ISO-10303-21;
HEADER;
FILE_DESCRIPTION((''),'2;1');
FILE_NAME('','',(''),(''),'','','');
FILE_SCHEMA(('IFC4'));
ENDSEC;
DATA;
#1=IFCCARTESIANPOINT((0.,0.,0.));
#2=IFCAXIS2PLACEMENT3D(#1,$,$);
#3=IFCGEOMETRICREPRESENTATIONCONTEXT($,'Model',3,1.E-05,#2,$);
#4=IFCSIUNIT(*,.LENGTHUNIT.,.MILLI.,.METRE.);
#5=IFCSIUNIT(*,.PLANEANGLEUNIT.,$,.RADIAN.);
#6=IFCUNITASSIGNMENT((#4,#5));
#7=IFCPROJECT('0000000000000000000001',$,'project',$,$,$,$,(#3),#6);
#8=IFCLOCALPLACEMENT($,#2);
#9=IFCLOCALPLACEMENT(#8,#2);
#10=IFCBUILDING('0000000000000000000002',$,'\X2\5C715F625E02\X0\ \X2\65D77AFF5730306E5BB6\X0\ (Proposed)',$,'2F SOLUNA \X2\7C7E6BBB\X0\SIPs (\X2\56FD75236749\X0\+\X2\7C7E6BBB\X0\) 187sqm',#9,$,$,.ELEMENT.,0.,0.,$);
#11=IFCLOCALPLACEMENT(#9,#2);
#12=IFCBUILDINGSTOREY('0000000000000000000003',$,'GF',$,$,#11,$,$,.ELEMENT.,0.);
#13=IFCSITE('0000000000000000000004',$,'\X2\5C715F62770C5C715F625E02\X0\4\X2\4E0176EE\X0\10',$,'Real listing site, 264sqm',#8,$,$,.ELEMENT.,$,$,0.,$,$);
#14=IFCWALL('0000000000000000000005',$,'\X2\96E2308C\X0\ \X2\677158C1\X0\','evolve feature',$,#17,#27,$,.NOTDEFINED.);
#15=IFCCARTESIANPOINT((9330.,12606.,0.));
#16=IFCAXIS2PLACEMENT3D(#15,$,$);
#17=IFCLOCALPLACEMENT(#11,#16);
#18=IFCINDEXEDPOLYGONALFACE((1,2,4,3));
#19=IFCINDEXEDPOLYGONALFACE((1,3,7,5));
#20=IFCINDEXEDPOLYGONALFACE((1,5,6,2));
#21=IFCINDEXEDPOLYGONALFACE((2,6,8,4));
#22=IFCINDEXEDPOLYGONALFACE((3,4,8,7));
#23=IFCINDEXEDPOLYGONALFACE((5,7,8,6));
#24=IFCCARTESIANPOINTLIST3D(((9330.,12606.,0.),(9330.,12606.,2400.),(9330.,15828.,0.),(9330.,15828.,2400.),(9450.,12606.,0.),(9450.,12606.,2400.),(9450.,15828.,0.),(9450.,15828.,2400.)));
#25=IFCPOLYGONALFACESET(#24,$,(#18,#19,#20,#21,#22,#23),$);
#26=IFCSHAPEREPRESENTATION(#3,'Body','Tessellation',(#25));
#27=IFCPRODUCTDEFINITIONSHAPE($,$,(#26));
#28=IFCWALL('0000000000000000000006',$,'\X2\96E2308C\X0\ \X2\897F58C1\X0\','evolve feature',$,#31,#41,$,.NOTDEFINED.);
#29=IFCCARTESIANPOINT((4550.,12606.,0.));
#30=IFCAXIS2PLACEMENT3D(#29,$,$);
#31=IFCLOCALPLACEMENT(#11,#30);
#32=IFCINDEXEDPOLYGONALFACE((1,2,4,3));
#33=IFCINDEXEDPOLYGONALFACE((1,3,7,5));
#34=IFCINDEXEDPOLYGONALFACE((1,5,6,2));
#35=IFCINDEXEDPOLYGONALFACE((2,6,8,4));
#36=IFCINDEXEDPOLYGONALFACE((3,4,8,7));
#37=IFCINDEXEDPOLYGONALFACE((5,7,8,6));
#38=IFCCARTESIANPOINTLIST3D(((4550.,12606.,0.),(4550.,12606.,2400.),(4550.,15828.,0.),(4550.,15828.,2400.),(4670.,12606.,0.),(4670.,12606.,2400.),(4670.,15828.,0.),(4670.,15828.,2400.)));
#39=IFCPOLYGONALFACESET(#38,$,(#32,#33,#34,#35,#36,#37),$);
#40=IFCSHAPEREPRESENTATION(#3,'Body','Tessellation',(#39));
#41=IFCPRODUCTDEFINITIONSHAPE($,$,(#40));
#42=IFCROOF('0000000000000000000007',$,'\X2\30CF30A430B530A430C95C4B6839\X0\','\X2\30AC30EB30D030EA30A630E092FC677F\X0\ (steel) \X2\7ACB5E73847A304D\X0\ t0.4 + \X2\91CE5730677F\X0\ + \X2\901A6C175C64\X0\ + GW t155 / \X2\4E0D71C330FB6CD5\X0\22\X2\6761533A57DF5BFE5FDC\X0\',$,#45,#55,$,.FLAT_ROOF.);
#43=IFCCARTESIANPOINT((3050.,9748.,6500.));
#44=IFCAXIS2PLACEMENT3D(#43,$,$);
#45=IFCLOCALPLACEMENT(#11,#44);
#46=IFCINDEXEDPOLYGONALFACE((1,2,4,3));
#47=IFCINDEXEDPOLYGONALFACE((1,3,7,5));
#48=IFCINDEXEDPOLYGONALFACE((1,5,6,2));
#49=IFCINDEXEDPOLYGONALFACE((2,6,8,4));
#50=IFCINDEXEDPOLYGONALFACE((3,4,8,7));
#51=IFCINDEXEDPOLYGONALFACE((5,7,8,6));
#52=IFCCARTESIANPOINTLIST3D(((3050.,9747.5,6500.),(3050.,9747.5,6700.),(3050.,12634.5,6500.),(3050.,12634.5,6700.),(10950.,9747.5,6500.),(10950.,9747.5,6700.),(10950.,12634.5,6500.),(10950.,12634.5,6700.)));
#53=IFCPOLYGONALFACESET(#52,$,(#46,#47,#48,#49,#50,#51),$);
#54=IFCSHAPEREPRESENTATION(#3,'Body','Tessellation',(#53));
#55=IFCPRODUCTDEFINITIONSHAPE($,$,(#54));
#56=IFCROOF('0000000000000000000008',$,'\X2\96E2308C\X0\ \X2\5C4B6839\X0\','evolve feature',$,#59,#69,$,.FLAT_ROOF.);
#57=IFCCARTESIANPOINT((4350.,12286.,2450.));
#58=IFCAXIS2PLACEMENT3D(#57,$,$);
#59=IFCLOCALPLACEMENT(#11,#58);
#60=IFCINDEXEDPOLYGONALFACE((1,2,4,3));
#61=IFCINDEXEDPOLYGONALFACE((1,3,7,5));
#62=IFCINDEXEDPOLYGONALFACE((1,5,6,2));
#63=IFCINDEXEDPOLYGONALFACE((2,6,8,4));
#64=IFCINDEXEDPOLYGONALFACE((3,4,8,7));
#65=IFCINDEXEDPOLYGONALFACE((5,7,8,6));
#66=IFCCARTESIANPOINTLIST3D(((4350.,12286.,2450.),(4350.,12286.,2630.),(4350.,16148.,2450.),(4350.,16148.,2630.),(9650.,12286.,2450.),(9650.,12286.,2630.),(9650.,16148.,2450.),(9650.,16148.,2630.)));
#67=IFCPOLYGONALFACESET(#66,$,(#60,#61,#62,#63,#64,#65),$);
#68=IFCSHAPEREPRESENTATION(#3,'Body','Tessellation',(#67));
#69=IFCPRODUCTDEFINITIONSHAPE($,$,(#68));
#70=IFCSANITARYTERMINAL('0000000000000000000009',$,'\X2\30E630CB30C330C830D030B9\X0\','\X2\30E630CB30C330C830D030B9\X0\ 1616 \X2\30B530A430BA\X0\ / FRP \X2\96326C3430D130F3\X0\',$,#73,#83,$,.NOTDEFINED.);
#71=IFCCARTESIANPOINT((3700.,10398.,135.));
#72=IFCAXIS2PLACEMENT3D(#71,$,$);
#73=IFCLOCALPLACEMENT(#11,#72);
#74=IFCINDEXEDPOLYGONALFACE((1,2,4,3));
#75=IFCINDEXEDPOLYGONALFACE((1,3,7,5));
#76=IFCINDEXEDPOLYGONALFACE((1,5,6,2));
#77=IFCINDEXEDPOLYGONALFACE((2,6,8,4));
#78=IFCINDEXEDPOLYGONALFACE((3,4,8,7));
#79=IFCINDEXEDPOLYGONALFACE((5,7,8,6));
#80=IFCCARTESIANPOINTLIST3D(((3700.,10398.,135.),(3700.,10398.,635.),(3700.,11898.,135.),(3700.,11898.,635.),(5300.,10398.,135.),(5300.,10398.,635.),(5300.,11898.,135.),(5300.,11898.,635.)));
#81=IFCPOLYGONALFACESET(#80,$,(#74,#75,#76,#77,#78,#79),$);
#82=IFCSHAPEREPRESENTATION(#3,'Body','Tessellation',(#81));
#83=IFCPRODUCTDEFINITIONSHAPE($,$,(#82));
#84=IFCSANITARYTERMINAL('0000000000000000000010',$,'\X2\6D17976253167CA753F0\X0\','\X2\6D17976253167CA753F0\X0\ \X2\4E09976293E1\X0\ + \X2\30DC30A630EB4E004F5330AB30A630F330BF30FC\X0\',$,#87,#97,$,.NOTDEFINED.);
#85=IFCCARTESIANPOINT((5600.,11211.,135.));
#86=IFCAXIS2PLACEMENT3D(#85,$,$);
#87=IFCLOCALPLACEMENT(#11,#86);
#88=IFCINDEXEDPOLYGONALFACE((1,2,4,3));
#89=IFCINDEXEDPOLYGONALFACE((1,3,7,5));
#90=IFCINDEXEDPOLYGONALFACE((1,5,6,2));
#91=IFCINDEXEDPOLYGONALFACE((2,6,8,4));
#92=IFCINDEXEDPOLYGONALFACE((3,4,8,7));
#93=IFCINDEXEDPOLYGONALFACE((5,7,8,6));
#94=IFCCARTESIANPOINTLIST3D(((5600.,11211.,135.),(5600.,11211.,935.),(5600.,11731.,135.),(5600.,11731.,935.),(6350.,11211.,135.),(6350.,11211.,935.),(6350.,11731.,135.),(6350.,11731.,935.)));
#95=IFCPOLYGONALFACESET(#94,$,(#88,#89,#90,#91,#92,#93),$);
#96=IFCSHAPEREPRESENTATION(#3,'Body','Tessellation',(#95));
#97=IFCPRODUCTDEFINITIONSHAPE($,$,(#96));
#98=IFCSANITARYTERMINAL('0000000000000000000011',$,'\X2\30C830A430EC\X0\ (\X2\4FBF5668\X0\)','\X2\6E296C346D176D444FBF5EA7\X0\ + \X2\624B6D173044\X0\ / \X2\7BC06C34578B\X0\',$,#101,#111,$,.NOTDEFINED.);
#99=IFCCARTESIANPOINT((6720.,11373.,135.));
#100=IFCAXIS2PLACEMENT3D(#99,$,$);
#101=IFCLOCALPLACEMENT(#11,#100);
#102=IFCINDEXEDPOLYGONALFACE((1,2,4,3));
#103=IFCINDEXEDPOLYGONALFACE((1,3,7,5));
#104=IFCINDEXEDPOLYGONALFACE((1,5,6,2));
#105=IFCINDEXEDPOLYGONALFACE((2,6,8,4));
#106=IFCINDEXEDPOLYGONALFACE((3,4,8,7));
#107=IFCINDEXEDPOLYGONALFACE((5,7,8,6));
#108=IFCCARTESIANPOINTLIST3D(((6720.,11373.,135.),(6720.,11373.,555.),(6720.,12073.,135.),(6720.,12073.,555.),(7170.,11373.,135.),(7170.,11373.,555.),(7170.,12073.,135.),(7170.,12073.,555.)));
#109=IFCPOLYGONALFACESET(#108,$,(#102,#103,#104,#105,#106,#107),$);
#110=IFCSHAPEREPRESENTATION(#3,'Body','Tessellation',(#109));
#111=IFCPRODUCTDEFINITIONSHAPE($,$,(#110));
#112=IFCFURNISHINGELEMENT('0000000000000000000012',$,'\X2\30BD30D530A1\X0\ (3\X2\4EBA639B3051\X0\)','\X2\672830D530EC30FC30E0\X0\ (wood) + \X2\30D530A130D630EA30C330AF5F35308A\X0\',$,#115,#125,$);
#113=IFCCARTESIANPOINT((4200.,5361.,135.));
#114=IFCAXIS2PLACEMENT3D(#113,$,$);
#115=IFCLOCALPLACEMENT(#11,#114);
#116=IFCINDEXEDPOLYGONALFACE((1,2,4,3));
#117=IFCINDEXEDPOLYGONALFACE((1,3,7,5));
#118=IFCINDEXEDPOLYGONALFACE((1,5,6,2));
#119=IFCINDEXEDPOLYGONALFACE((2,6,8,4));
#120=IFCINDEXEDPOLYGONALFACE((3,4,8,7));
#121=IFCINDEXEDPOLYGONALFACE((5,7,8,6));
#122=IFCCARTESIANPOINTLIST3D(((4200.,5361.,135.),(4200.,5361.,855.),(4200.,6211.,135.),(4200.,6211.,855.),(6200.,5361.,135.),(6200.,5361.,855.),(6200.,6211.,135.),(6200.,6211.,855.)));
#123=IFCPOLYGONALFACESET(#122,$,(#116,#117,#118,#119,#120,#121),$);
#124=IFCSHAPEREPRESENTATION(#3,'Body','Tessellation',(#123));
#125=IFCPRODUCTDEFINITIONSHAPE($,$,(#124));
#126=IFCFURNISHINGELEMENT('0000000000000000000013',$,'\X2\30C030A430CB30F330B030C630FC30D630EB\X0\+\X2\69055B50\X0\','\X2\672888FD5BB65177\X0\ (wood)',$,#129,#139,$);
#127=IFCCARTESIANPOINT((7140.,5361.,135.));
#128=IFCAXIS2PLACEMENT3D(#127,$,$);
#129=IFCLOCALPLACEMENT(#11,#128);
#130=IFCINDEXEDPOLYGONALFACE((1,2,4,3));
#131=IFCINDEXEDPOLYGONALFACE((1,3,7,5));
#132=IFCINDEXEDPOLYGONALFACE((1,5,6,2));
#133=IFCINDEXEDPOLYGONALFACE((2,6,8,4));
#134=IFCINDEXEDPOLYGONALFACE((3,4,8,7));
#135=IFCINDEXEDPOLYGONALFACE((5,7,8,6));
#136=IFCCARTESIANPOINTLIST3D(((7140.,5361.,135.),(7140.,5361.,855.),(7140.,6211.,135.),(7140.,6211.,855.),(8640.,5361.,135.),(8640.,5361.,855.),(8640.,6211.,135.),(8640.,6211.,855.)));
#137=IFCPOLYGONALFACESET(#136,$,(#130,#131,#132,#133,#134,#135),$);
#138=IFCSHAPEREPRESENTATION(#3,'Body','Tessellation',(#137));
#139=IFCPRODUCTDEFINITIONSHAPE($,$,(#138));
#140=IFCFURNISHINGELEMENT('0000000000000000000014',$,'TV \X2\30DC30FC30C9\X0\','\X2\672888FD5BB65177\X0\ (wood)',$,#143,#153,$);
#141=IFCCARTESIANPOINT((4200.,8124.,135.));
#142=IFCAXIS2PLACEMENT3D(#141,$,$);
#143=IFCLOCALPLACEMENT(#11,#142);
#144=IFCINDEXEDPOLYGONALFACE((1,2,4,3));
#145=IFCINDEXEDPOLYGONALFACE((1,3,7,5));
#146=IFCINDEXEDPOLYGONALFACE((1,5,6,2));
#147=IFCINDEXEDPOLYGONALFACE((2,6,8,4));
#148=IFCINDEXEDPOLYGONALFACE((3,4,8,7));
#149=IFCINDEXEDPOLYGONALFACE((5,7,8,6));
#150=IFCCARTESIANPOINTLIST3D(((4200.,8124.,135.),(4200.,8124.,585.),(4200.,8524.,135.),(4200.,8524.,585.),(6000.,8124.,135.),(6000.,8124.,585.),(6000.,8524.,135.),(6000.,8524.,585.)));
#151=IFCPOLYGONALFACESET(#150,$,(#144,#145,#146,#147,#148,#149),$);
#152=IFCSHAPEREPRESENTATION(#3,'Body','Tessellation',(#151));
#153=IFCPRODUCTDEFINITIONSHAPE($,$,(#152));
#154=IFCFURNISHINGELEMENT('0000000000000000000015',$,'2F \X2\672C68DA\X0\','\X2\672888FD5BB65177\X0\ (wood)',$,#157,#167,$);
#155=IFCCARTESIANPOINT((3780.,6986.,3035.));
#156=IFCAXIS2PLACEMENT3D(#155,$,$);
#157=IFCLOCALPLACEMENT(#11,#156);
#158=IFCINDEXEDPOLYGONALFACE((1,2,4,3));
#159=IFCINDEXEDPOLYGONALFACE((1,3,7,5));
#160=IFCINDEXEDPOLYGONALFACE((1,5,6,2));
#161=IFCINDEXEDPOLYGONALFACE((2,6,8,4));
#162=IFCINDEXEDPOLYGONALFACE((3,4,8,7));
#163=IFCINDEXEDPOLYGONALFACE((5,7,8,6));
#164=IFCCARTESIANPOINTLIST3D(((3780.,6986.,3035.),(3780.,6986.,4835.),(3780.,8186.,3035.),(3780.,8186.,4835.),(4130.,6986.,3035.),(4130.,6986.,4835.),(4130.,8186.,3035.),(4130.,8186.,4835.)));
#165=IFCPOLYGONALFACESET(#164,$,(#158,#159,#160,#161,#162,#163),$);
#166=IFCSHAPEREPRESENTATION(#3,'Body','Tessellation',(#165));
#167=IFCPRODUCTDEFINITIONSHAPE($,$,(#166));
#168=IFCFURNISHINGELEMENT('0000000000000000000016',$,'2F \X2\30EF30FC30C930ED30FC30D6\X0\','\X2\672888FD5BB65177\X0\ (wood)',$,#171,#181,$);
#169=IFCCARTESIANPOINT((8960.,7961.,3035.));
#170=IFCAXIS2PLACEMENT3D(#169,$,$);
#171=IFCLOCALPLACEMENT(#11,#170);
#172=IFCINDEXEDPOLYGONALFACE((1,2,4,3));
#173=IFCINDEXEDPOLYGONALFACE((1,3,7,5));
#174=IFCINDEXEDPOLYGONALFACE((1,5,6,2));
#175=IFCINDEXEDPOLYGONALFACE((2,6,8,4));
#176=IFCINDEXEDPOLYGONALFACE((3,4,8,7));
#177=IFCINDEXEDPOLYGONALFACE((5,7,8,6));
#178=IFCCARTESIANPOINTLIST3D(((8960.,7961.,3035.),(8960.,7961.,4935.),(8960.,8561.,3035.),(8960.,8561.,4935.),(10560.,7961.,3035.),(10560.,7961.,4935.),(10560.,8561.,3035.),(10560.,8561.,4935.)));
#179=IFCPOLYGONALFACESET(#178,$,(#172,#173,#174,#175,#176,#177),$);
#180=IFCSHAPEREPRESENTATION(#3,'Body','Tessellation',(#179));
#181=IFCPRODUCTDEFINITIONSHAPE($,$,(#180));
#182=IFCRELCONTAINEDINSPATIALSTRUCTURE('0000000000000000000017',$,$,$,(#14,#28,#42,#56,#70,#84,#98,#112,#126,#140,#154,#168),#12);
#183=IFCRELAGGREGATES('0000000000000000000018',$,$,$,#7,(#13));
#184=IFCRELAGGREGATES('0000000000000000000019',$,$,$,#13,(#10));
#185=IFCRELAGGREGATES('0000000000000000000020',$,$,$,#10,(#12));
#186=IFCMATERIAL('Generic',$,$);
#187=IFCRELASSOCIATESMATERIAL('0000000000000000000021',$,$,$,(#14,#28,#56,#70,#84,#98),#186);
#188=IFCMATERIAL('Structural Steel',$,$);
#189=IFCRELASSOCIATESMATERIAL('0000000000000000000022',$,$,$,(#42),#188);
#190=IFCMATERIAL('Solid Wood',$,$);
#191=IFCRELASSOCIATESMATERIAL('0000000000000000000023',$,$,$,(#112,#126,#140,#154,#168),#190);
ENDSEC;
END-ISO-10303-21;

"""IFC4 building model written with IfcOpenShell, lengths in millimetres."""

from ifc_helpers import new_model, si_unit, frame, frame_2d, origin, place, context, project, spatial, rectangle, extrude, material, element, save


model = new_model("IFC4")

# Units and contexts
model_context = context("Model", 3, precision=1e-05, world=origin())
ifc_project = project(units=[si_unit("LENGTHUNIT", "METRE", prefix="MILLI"), si_unit("PLANEANGLEUNIT", "RADIAN")], contexts=[model_context])

# Site, building, storey
site_placement = place(None, origin())
site = spatial("IfcSite", under=ifc_project, at=site_placement, Name="山形県山形市4丁目10", ObjectType="Real listing site, 264sqm", CompositionType="ELEMENT", RefElevation=0.0)
building_placement = place(site_placement, origin())
building = spatial("IfcBuilding", under=site, at=building_placement, Name="山形市 旗竿地の家 (Proposed)", ObjectType="2F SOLUNA 籾殻SIPs (国産杉+籾殻) 187sqm", CompositionType="ELEMENT", ElevationOfRefHeight=0.0, ElevationOfTerrain=0.0)
storey_placement = place(building_placement, origin())
storey = spatial("IfcBuildingStorey", under=building, at=storey_placement, Name="GF", CompositionType="ELEMENT", Elevation=0.0)

# Shared definitions
ifc_material_1 = material(Name="Generic")

# Shared definitions
ifc_material_2 = material(Name="Solid Wood")

# Walls
wall_1_placement = place(storey_placement, frame((9330.0, 12606.0, 0.0)))
element("IfcWall", 1, at=wall_1_placement, inside=storey, material=ifc_material_1, Name="離れ 東壁", Description="evolve feature", PredefinedType="NOTDEFINED", context=model_context, shape_type="SweptSolid", body=[
    extrude(rectangle(XDim=120.0, YDim=3222.0, at=frame_2d((60.0, 1611.0))), frame((9330.0, 12606.0, 0.0)), (0.0, 0.0, 1.0), 2400.0),
])
wall_2_placement = place(storey_placement, frame((4550.0, 12606.0, 0.0)))
element("IfcWall", 2, at=wall_2_placement, inside=storey, material=ifc_material_1, Name="離れ 西壁", Description="evolve feature", PredefinedType="NOTDEFINED", context=model_context, shape_type="SweptSolid", body=[
    extrude(rectangle(XDim=120.0, YDim=3222.0, at=frame_2d((60.0, 1611.0))), frame((4550.0, 12606.0, 0.0)), (0.0, 0.0, 1.0), 2400.0),
])

# Roofs
ifc_material_3 = material(Name="Structural Steel")
roof_1_placement = place(storey_placement, frame((3050.0, 9748.0, 6500.0)))
element("IfcRoof", 3, at=roof_1_placement, inside=storey, material=ifc_material_3, Name="ハイサイド屋根", Description="ガルバリウム鋼板 (steel) 立平葺き t0.4 + 野地板 + 通気層 + GW t155 / 不燃・法22条区域対応", PredefinedType="FLAT_ROOF", context=model_context, shape_type="SweptSolid", body=[
    extrude(rectangle(XDim=7900.0, YDim=2887.0, at=frame_2d((3950.0, 1443.0))), frame((3050.0, 9748.0, 6500.0)), (0.0, 0.0, 1.0), 200.0),
])
roof_2_placement = place(storey_placement, frame((4350.0, 12286.0, 2450.0)))
element("IfcRoof", 4, at=roof_2_placement, inside=storey, material=ifc_material_1, Name="離れ 屋根", Description="evolve feature", PredefinedType="FLAT_ROOF", context=model_context, shape_type="SweptSolid", body=[
    extrude(rectangle(XDim=5300.0, YDim=3862.0, at=frame_2d((2650.0, 1931.0))), frame((4350.0, 12286.0, 2450.0)), (0.0, 0.0, 1.0), 180.0),
])

# Sanitary terminals
sanitary_terminal_1_placement = place(storey_placement, frame((3700.0, 10398.0, 135.0)))
element("IfcSanitaryTerminal", 5, at=sanitary_terminal_1_placement, inside=storey, material=ifc_material_1, Name="ユニットバス", Description="ユニットバス 1616 サイズ / FRP 防水パン", PredefinedType="NOTDEFINED", context=model_context, shape_type="SweptSolid", body=[
    extrude(rectangle(XDim=1600.0, YDim=1500.0, at=frame_2d((800.0, 750.0))), frame((3700.0, 10398.0, 135.0)), (0.0, 0.0, 1.0), 500.0),
])
sanitary_terminal_2_placement = place(storey_placement, frame((5600.0, 11211.0, 135.0)))
element("IfcSanitaryTerminal", 6, at=sanitary_terminal_2_placement, inside=storey, material=ifc_material_1, Name="洗面化粧台", Description="洗面化粧台 三面鏡 + ボウル一体カウンター", PredefinedType="NOTDEFINED", context=model_context, shape_type="SweptSolid", body=[
    extrude(rectangle(XDim=750.0, YDim=520.0, at=frame_2d((375.0, 260.0))), frame((5600.0, 11211.0, 135.0)), (0.0, 0.0, 1.0), 800.0),
])
sanitary_terminal_3_placement = place(storey_placement, frame((6720.0, 11373.0, 135.0)))
element("IfcSanitaryTerminal", 7, at=sanitary_terminal_3_placement, inside=storey, material=ifc_material_1, Name="トイレ (便器)", Description="温水洗浄便座 + 手洗い / 節水型", PredefinedType="NOTDEFINED", context=model_context, shape_type="SweptSolid", body=[
    extrude(rectangle(XDim=450.0, YDim=700.0, at=frame_2d((225.0, 350.0))), frame((6720.0, 11373.0, 135.0)), (0.0, 0.0, 1.0), 420.0),
])

# Furnishing elements
furnishing_1_placement = place(storey_placement, frame((4200.0, 5361.0, 135.0)))
element("IfcFurnishingElement", 8, at=furnishing_1_placement, inside=storey, material=ifc_material_2, Name="ソファ (3人掛け)", Description="木フレーム (wood) + ファブリック張り", context=model_context, shape_type="SweptSolid", body=[
    extrude(rectangle(XDim=2000.0, YDim=850.0, at=frame_2d((1000.0, 425.0))), frame((4200.0, 5361.0, 135.0)), (0.0, 0.0, 1.0), 720.0),
])
furnishing_2_placement = place(storey_placement, frame((7140.0, 5361.0, 135.0)))
element("IfcFurnishingElement", 9, at=furnishing_2_placement, inside=storey, material=ifc_material_2, Name="ダイニングテーブル+椅子", Description="木製家具 (wood)", context=model_context, shape_type="SweptSolid", body=[
    extrude(rectangle(XDim=1500.0, YDim=850.0, at=frame_2d((750.0, 425.0))), frame((7140.0, 5361.0, 135.0)), (0.0, 0.0, 1.0), 720.0),
])
furnishing_3_placement = place(storey_placement, frame((4200.0, 8124.0, 135.0)))
element("IfcFurnishingElement", 10, at=furnishing_3_placement, inside=storey, material=ifc_material_2, Name="TV ボード", Description="木製家具 (wood)", context=model_context, shape_type="SweptSolid", body=[
    extrude(rectangle(XDim=1800.0, YDim=400.0, at=frame_2d((900.0, 200.0))), frame((4200.0, 8124.0, 135.0)), (0.0, 0.0, 1.0), 450.0),
])
furnishing_4_placement = place(storey_placement, frame((3780.0, 6986.0, 3035.0)))
element("IfcFurnishingElement", 11, at=furnishing_4_placement, inside=storey, material=ifc_material_2, Name="2F 本棚", Description="木製家具 (wood)", context=model_context, shape_type="SweptSolid", body=[
    extrude(rectangle(XDim=350.0, YDim=1200.0, at=frame_2d((175.0, 600.0))), frame((3780.0, 6986.0, 3035.0)), (0.0, 0.0, 1.0), 1800.0),
])
furnishing_5_placement = place(storey_placement, frame((8960.0, 7961.0, 3035.0)))
element("IfcFurnishingElement", 12, at=furnishing_5_placement, inside=storey, material=ifc_material_2, Name="2F ワードローブ", Description="木製家具 (wood)", context=model_context, shape_type="SweptSolid", body=[
    extrude(rectangle(XDim=1600.0, YDim=600.0, at=frame_2d((800.0, 300.0))), frame((8960.0, 7961.0, 3035.0)), (0.0, 0.0, 1.0), 1900.0),
])

save(model, "model.ifc")
